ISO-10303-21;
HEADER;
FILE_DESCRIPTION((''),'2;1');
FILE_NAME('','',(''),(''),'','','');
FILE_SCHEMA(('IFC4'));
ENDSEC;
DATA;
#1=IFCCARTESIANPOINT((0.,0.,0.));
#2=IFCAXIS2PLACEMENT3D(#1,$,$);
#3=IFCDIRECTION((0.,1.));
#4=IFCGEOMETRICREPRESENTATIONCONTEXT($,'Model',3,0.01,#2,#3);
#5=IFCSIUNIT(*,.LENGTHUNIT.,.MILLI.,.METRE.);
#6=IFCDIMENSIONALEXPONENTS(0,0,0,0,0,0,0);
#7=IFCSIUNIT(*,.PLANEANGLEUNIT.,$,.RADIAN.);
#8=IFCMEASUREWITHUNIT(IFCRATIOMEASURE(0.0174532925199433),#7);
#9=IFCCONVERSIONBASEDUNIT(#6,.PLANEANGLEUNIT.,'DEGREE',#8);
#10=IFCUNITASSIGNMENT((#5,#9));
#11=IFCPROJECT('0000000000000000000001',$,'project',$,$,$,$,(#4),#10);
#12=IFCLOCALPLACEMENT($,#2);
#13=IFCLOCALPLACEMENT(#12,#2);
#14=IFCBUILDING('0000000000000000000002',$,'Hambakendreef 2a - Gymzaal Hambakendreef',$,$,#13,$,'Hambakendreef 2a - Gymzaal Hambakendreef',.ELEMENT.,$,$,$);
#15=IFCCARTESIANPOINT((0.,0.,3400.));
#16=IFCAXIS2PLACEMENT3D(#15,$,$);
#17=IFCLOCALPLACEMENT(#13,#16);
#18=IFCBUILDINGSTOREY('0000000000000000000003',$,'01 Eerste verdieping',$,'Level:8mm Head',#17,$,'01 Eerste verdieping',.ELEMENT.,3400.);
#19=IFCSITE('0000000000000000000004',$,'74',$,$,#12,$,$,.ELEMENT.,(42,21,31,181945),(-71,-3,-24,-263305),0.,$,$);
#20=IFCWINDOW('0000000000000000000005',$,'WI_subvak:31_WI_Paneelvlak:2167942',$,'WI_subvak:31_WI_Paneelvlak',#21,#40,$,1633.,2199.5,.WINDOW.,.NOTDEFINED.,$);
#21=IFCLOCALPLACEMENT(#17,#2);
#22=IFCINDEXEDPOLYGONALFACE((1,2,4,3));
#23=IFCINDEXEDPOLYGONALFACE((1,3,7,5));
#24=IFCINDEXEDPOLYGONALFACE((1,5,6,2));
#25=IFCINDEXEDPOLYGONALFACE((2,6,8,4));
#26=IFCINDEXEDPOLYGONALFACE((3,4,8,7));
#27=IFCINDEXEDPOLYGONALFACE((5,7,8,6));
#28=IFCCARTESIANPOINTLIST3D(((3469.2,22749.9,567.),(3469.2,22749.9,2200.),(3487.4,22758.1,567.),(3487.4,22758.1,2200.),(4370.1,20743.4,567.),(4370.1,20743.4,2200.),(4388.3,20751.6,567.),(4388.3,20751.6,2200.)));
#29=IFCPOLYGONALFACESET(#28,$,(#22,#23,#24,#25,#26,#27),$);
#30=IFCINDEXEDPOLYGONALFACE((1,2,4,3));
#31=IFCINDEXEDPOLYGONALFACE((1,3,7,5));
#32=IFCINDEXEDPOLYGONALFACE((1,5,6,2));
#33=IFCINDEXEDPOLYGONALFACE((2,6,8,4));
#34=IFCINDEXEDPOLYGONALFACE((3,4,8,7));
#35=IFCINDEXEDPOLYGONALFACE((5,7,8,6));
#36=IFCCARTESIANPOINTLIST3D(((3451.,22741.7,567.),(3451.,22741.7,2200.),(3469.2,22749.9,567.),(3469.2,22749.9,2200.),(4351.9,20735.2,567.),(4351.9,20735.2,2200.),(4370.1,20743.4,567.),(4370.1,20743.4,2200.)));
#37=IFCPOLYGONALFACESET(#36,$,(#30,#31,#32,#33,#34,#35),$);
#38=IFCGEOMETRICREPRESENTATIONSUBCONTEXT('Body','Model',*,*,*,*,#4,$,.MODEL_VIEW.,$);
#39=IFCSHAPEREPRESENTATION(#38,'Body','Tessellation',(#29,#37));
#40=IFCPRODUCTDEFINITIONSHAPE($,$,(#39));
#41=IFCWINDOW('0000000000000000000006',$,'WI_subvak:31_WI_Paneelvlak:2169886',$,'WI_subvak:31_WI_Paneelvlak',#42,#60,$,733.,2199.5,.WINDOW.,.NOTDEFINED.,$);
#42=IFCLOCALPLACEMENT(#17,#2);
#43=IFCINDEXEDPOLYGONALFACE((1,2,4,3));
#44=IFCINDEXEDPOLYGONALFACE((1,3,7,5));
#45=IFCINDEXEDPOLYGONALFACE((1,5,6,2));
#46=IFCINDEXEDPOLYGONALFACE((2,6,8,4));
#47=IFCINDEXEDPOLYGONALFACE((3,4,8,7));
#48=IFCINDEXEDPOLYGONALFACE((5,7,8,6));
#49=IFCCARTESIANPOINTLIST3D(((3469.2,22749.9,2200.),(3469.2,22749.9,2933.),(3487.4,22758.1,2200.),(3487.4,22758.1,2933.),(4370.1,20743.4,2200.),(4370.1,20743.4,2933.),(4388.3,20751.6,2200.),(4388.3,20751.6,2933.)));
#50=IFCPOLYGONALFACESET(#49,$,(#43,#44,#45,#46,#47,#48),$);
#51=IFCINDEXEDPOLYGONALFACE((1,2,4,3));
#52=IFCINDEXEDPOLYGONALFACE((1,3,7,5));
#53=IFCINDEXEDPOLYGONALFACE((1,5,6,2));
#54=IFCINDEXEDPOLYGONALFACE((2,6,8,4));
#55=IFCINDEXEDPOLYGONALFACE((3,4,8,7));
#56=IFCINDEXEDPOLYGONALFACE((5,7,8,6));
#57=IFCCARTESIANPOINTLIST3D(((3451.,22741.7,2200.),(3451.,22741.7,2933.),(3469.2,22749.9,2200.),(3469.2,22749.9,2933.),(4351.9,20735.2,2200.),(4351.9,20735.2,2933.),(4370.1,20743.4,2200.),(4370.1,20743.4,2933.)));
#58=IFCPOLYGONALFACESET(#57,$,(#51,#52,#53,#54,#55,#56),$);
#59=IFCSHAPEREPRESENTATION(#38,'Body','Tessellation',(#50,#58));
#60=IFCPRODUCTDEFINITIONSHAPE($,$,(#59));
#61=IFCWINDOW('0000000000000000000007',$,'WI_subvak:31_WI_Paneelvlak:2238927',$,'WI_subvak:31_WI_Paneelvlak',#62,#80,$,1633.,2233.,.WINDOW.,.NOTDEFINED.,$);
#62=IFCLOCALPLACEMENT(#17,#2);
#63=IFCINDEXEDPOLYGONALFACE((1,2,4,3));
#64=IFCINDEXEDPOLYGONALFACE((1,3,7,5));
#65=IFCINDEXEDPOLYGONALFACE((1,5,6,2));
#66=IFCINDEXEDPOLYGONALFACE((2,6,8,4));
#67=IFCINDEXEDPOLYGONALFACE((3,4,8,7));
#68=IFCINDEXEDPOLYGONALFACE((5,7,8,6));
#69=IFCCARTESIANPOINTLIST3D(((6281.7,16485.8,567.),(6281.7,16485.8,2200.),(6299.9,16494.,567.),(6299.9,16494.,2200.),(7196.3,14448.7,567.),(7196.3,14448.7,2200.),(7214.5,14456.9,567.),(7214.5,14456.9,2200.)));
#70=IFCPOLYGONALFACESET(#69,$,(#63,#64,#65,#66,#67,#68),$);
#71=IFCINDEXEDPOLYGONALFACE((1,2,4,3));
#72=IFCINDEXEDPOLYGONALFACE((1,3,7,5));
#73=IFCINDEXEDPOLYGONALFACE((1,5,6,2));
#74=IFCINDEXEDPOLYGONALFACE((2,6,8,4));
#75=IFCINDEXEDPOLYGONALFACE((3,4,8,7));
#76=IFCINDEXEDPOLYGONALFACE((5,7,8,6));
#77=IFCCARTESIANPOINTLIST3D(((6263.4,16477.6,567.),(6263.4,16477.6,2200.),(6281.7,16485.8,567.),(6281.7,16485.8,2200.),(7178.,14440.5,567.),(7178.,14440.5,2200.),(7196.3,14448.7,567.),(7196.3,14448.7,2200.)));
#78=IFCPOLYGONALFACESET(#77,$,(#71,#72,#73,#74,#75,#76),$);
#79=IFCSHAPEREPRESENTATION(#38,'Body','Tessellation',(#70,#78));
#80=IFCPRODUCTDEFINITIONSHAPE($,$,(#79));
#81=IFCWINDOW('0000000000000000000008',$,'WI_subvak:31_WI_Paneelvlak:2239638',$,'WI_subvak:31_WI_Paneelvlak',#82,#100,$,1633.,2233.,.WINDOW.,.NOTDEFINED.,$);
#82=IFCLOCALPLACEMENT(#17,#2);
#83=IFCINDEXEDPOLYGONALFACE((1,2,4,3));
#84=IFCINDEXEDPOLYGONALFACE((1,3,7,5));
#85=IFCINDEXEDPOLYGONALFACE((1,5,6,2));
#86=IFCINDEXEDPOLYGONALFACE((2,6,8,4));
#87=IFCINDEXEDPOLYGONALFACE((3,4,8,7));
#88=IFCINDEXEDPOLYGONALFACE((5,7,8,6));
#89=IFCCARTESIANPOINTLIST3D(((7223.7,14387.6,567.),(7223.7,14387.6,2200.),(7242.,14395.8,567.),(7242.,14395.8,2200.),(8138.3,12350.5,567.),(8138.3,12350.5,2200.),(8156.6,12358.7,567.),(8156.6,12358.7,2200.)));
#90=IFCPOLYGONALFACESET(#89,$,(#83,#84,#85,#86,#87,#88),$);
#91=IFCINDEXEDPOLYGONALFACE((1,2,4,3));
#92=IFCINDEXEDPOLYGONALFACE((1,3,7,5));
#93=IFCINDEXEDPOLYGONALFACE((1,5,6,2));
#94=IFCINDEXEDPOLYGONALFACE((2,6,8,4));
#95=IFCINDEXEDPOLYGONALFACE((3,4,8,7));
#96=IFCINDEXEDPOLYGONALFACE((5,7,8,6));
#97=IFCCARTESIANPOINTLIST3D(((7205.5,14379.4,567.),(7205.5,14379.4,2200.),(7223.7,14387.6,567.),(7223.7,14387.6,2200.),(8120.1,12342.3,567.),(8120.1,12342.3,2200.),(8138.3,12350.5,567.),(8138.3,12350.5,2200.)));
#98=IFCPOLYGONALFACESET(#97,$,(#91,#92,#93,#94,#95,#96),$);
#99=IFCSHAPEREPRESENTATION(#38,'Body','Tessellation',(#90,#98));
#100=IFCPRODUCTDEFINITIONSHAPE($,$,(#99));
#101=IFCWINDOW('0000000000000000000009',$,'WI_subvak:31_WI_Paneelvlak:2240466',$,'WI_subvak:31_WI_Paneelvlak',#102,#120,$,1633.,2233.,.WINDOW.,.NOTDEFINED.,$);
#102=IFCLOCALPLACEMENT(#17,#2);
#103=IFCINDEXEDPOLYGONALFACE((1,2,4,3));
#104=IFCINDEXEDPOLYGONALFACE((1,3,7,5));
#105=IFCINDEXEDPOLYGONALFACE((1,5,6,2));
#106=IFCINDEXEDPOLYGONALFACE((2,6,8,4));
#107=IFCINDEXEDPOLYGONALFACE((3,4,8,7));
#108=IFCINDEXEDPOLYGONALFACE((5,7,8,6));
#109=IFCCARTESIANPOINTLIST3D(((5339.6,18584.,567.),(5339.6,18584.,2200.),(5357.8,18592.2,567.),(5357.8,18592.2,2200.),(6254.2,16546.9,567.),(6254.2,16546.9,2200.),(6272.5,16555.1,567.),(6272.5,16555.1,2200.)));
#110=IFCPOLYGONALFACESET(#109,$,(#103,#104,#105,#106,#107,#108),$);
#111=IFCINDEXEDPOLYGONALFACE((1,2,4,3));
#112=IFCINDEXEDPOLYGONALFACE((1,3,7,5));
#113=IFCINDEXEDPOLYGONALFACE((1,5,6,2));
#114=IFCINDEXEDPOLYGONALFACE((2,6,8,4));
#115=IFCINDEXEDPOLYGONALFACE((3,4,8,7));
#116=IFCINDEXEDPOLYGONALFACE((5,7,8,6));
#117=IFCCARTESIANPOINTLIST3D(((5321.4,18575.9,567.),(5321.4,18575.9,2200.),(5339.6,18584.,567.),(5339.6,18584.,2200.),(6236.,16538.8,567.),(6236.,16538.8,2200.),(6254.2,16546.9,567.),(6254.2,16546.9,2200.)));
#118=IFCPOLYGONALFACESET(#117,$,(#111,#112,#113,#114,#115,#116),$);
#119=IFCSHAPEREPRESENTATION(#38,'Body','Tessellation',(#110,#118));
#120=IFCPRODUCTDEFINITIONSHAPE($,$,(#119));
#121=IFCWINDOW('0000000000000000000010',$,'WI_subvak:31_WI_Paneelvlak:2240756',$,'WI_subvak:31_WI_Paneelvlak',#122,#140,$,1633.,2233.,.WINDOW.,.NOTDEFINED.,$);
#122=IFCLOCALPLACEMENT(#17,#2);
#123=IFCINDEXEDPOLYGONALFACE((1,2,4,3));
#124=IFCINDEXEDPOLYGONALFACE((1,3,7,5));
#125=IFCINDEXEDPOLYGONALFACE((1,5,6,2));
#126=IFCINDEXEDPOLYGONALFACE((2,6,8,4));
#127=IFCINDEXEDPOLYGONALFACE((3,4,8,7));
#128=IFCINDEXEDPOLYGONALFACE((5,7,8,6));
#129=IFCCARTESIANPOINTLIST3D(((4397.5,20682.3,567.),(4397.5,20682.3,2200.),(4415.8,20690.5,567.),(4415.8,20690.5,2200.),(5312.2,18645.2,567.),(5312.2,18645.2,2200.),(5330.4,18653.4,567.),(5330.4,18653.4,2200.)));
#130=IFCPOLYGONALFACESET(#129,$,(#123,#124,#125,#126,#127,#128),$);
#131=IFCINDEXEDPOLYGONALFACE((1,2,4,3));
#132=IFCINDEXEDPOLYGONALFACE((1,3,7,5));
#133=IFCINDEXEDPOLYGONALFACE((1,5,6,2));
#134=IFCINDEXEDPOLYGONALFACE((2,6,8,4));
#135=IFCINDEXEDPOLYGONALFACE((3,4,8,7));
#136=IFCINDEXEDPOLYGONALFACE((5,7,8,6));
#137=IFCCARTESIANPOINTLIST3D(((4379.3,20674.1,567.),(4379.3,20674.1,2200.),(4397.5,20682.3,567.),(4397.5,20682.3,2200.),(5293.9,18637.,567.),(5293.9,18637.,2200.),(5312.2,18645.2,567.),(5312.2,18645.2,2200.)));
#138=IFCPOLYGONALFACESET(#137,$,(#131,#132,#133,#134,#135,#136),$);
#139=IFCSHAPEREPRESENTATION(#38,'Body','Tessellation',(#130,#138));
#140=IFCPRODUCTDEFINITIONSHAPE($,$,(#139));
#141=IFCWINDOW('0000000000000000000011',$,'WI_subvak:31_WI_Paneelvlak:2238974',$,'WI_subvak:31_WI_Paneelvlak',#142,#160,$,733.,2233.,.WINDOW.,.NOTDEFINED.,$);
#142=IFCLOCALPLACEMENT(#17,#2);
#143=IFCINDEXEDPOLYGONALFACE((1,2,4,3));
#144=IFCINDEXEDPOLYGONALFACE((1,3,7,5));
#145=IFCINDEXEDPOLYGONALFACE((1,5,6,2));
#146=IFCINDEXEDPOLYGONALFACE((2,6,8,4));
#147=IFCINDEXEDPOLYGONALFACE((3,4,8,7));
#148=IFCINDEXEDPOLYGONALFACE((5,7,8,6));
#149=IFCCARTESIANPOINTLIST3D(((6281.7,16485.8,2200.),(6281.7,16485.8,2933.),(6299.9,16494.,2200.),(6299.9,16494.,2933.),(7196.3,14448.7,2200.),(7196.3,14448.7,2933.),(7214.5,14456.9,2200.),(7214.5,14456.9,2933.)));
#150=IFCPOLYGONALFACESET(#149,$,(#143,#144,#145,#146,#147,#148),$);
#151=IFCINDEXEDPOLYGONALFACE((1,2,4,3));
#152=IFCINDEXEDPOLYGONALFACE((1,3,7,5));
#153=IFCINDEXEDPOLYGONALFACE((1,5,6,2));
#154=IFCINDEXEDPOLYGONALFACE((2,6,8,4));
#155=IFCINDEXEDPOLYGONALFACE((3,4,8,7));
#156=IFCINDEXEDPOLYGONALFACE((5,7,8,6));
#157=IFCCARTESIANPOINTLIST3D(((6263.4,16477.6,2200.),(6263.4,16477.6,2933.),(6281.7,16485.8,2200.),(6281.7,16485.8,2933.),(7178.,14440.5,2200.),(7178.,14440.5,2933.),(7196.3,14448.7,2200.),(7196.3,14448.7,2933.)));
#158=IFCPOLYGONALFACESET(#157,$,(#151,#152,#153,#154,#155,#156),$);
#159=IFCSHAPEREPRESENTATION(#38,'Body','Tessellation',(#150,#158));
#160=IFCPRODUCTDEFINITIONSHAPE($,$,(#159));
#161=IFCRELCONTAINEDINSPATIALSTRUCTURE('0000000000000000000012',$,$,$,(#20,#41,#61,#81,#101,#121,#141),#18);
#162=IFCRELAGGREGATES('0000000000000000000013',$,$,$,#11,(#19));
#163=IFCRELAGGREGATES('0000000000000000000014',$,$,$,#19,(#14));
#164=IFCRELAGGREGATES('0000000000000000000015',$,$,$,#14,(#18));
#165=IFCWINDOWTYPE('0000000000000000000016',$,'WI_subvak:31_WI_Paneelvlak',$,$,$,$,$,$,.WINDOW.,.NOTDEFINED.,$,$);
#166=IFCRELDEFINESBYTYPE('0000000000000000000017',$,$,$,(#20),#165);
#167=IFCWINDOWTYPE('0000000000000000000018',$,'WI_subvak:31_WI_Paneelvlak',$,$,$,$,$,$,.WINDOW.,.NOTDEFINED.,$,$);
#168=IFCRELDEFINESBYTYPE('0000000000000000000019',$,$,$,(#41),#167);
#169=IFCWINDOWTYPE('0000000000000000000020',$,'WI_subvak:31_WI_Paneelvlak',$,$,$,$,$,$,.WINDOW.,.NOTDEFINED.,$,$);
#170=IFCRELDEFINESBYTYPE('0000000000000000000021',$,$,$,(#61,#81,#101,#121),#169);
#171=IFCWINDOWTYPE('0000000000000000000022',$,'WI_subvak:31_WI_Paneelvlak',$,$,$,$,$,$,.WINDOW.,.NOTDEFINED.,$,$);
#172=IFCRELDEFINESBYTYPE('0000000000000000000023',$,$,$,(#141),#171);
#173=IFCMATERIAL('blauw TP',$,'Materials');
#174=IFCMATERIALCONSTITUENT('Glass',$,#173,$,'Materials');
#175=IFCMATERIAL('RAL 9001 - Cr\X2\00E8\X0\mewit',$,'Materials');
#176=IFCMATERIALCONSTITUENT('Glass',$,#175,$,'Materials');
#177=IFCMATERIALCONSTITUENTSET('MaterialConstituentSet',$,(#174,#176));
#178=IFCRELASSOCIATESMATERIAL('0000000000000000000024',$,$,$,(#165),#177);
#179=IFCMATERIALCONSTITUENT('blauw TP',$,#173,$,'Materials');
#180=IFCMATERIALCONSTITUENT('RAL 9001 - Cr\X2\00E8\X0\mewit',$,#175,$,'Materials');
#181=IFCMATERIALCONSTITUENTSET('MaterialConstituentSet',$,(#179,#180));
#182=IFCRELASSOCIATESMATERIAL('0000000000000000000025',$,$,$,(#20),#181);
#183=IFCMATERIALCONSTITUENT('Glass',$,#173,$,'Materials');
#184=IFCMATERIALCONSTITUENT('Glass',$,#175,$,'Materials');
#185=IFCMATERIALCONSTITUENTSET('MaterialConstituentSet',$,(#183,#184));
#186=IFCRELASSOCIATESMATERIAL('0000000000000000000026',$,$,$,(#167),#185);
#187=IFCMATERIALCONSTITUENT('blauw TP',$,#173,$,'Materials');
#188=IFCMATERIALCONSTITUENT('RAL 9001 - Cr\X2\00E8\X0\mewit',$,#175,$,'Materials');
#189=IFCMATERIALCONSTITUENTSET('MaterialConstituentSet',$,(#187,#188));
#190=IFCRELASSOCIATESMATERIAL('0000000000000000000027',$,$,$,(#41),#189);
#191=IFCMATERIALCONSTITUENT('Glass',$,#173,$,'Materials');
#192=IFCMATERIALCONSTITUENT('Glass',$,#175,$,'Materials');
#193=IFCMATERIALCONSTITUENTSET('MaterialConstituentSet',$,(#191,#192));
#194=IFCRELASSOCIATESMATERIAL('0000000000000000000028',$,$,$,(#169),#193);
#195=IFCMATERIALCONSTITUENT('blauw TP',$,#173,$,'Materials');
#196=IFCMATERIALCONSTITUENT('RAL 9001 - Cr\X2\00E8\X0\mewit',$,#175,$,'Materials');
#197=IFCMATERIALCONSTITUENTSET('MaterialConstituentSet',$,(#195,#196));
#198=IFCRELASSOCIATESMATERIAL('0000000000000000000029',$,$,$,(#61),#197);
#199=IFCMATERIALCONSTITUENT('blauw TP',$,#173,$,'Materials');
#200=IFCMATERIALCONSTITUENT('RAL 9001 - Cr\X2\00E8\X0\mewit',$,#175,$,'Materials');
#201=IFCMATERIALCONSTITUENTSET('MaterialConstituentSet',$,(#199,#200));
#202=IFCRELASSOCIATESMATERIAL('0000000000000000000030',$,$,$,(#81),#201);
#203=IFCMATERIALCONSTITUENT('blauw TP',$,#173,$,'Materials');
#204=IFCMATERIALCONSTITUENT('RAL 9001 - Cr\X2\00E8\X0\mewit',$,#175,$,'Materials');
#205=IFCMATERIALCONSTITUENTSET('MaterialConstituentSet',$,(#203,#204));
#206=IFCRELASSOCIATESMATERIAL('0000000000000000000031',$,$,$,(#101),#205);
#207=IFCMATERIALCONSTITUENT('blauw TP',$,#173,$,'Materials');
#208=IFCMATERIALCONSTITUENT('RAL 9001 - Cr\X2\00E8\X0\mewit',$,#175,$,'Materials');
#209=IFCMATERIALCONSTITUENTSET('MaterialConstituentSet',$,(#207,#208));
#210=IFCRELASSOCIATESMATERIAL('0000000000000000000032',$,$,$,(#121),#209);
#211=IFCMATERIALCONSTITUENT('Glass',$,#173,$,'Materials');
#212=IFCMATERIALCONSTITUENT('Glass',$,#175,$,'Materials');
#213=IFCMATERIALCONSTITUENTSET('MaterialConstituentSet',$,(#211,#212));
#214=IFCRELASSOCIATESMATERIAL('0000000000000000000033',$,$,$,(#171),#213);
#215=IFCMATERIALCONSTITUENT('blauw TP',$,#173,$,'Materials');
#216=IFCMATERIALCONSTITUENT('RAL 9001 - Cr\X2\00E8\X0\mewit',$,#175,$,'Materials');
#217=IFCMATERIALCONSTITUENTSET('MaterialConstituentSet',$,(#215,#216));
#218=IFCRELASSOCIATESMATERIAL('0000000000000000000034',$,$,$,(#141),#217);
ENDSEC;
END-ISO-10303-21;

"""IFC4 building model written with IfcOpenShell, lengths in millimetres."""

from ifc_helpers import new_model, entity, si_unit, converted_unit, direction, frame, origin, place, context, subcontext, project, spatial, indexed_curve, outline, extrude, source, transform, mapped, material, constituent, constituent_set, type_object, type_shapes, element, save


model = new_model("IFC4")

# Units and contexts
model_context = context("Model", 3, precision=0.01, world=origin(), true_north=direction((0.0, 1.0)))
body_context = subcontext(model_context, "Body", "Model", "MODEL_VIEW")
ifc_project = project(units=[si_unit("LENGTHUNIT", "METRE", prefix="MILLI"), converted_unit("PLANEANGLEUNIT", "DEGREE", entity("IfcRatioMeasure", 0.0174532925199433), si_unit("PLANEANGLEUNIT", "RADIAN"), dimensions=[0, 0, 0, 0, 0, 0, 0])], contexts=[model_context])

# Site, building, storey
site_placement = place(None, origin())
site = spatial("IfcSite", under=ifc_project, at=site_placement, Name="74", CompositionType="ELEMENT", RefLatitude=(42, 21, 31, 181945), RefLongitude=(-71, -3, -24, -263305), RefElevation=0.0)
building_placement = place(site_placement, origin())
building = spatial("IfcBuilding", under=site, at=building_placement, Name="Hambakendreef 2a - Gymzaal Hambakendreef", LongName="Hambakendreef 2a - Gymzaal Hambakendreef", CompositionType="ELEMENT")
storey_placement = place(building_placement, frame((0.0, 0.0, 3400.0)))
storey = spatial("IfcBuildingStorey", under=building, at=storey_placement, Name="01 Eerste verdieping", ObjectType="Level:8mm Head", LongName="01 Eerste verdieping", CompositionType="ELEMENT", Elevation=3400.0)

# Windows
ifc_material_1 = material(Name="blauw TP", Category="Materials")
ifc_constituent_1 = constituent(ifc_material_1, Name="blauw TP", Category="Materials")
ifc_material_2 = material(Name="RAL 9001 - Crèmewit", Category="Materials")
ifc_constituent_2 = constituent(ifc_material_2, Name="RAL 9001 - Crèmewit", Category="Materials")
ifc_constituent_set_1 = constituent_set(constituents=[ifc_constituent_1, ifc_constituent_2], Name="MaterialConstituentSet")
ifc_constituent_3 = constituent(ifc_material_1, Name="Glass", Category="Materials")
ifc_constituent_4 = constituent(ifc_material_2, Name="Glass", Category="Materials")
ifc_constituent_set_2 = constituent_set(constituents=[ifc_constituent_3, ifc_constituent_4], Name="MaterialConstituentSet")
window_type_1 = type_object("IfcWindowType", Name="WI_subvak:31_WI_Paneelvlak", PartitioningType="NOTDEFINED", PredefinedType="WINDOW", material=ifc_constituent_set_2)
shared_shape_1 = source(origin(), body_context, "Body", "SweptSolid", [
    extrude(outline(indexed_curve([(-10.0, -1099.8), (10.0, -1099.8), (10.0, 1099.8), (-10.0, 1099.8), (-10.0, -1099.8)], self_intersect=False)), frame((0.0, 10.0, 0.0), z_axis=(0.0, 0.0, 1.0), x_axis=(0.0, -1.0, 0.0)), (0.0, 0.0, 1.0), 1633.0),
    extrude(outline(indexed_curve([(-10.0, -1099.8), (10.0, -1099.8), (10.0, 1099.8), (-10.0, 1099.8), (-10.0, -1099.8)], self_intersect=False)), frame((0.0, -10.0, 0.0), z_axis=(0.0, 0.0, 1.0), x_axis=(0.0, -1.0, 0.0)), (0.0, 0.0, 1.0), 1633.0),
])
type_shapes(window_type_1, [shared_shape_1])
window_1_placement = place(storey_placement, frame((3919.7, 21746.7, 567.0), z_axis=(0.0, 0.0, 1.0), x_axis=(0.40959, -0.91227, 0.0)))
element("IfcWindow", 1, at=window_1_placement, inside=storey, type_object=window_type_1, material=ifc_constituent_set_1, Name="WI_subvak:31_WI_Paneelvlak:2167942", ObjectType="WI_subvak:31_WI_Paneelvlak", OverallHeight=1633.0, OverallWidth=2199.5, PartitioningType="NOTDEFINED", PredefinedType="WINDOW", context=body_context, shape_type="MappedRepresentation", body=[
    mapped(shared_shape_1, transform((0.0, 0.0, 0.0), scale=1.0)),
])
ifc_constituent_5 = constituent(ifc_material_1, Name="blauw TP", Category="Materials")
ifc_constituent_6 = constituent(ifc_material_2, Name="RAL 9001 - Crèmewit", Category="Materials")
ifc_constituent_set_3 = constituent_set(constituents=[ifc_constituent_5, ifc_constituent_6], Name="MaterialConstituentSet")
ifc_constituent_7 = constituent(ifc_material_1, Name="Glass", Category="Materials")
ifc_constituent_8 = constituent(ifc_material_2, Name="Glass", Category="Materials")
ifc_constituent_set_4 = constituent_set(constituents=[ifc_constituent_7, ifc_constituent_8], Name="MaterialConstituentSet")
window_type_2 = type_object("IfcWindowType", Name="WI_subvak:31_WI_Paneelvlak", PartitioningType="NOTDEFINED", PredefinedType="WINDOW", material=ifc_constituent_set_4)
shared_shape_2 = source(origin(), body_context, "Body", "SweptSolid", [
    extrude(outline(indexed_curve([(-10.0, -1099.8), (10.0, -1099.8), (10.0, 1099.8), (-10.0, 1099.8), (-10.0, -1099.8)], self_intersect=False)), frame((0.0, 10.0, 0.0), z_axis=(0.0, 0.0, 1.0), x_axis=(0.0, -1.0, 0.0)), (0.0, 0.0, 1.0), 733.0),
    extrude(outline(indexed_curve([(-10.0, -1099.8), (10.0, -1099.8), (10.0, 1099.8), (-10.0, 1099.8), (-10.0, -1099.8)], self_intersect=False)), frame((0.0, -10.0, 0.0), z_axis=(0.0, 0.0, 1.0), x_axis=(0.0, -1.0, 0.0)), (0.0, 0.0, 1.0), 733.0),
])
type_shapes(window_type_2, [shared_shape_2])
window_2_placement = place(storey_placement, frame((3919.7, 21746.7, 2200.0), z_axis=(0.0, 0.0, 1.0), x_axis=(0.40959, -0.91227, 0.0)))
element("IfcWindow", 2, at=window_2_placement, inside=storey, type_object=window_type_2, material=ifc_constituent_set_3, Name="WI_subvak:31_WI_Paneelvlak:2169886", ObjectType="WI_subvak:31_WI_Paneelvlak", OverallHeight=733.0, OverallWidth=2199.5, PartitioningType="NOTDEFINED", PredefinedType="WINDOW", context=body_context, shape_type="MappedRepresentation", body=[
    mapped(shared_shape_2, transform((0.0, 0.0, 0.0), scale=1.0)),
])
ifc_constituent_9 = constituent(ifc_material_1, Name="blauw TP", Category="Materials")
ifc_constituent_10 = constituent(ifc_material_2, Name="RAL 9001 - Crèmewit", Category="Materials")
ifc_constituent_set_5 = constituent_set(constituents=[ifc_constituent_9, ifc_constituent_10], Name="MaterialConstituentSet")
ifc_constituent_11 = constituent(ifc_material_1, Name="Glass", Category="Materials")
ifc_constituent_12 = constituent(ifc_material_2, Name="Glass", Category="Materials")
ifc_constituent_set_6 = constituent_set(constituents=[ifc_constituent_11, ifc_constituent_12], Name="MaterialConstituentSet")
window_type_3 = type_object("IfcWindowType", Name="WI_subvak:31_WI_Paneelvlak", PartitioningType="NOTDEFINED", PredefinedType="WINDOW", material=ifc_constituent_set_6)
shared_shape_3 = source(origin(), body_context, "Body", "SweptSolid", [
    extrude(outline(indexed_curve([(-10.0, -1116.5), (10.0, -1116.5), (10.0, 1116.5), (-10.0, 1116.5), (-10.0, -1116.5)], self_intersect=False)), frame((0.0, 10.0, 0.0), z_axis=(0.0, 0.0, 1.0), x_axis=(0.0, -1.0, 0.0)), (0.0, 0.0, 1.0), 1633.0),
    extrude(outline(indexed_curve([(-10.0, -1116.5), (10.0, -1116.5), (10.0, 1116.5), (-10.0, 1116.5), (-10.0, -1116.5)], self_intersect=False)), frame((0.0, -10.0, 0.0), z_axis=(0.0, 0.0, 1.0), x_axis=(0.0, -1.0, 0.0)), (0.0, 0.0, 1.0), 1633.0),
])
type_shapes(window_type_3, [shared_shape_3])
window_3_placement = place(storey_placement, frame((6739.0, 15467.3, 567.0), z_axis=(0.0, 0.0, 1.0), x_axis=(0.40959, -0.91227, 0.0)))
element("IfcWindow", 3, at=window_3_placement, inside=storey, type_object=window_type_3, material=ifc_constituent_set_5, Name="WI_subvak:31_WI_Paneelvlak:2238927", ObjectType="WI_subvak:31_WI_Paneelvlak", OverallHeight=1633.0, OverallWidth=2233.0, PartitioningType="NOTDEFINED", PredefinedType="WINDOW", context=body_context, shape_type="MappedRepresentation", body=[
    mapped(shared_shape_3, transform((0.0, 0.0, 0.0), scale=1.0)),
])
ifc_constituent_13 = constituent(ifc_material_1, Name="blauw TP", Category="Materials")
ifc_constituent_14 = constituent(ifc_material_2, Name="RAL 9001 - Crèmewit", Category="Materials")
ifc_constituent_set_7 = constituent_set(constituents=[ifc_constituent_13, ifc_constituent_14], Name="MaterialConstituentSet")
window_4_placement = place(storey_placement, frame((7681.0, 13369.1, 567.0), z_axis=(0.0, 0.0, 1.0), x_axis=(0.40959, -0.91227, 0.0)))
element("IfcWindow", 4, at=window_4_placement, inside=storey, type_object=window_type_3, material=ifc_constituent_set_7, Name="WI_subvak:31_WI_Paneelvlak:2239638", ObjectType="WI_subvak:31_WI_Paneelvlak", OverallHeight=1633.0, OverallWidth=2233.0, PartitioningType="NOTDEFINED", PredefinedType="WINDOW", context=body_context, shape_type="MappedRepresentation", body=[
    mapped(shared_shape_3, transform((0.0, 0.0, 0.0), scale=1.0)),
])
ifc_constituent_15 = constituent(ifc_material_1, Name="blauw TP", Category="Materials")
ifc_constituent_16 = constituent(ifc_material_2, Name="RAL 9001 - Crèmewit", Category="Materials")
ifc_constituent_set_8 = constituent_set(constituents=[ifc_constituent_15, ifc_constituent_16], Name="MaterialConstituentSet")
window_5_placement = place(storey_placement, frame((5796.9, 17565.5, 567.0), z_axis=(0.0, 0.0, 1.0), x_axis=(0.40959, -0.91227, 0.0)))
element("IfcWindow", 5, at=window_5_placement, inside=storey, type_object=window_type_3, material=ifc_constituent_set_8, Name="WI_subvak:31_WI_Paneelvlak:2240466", ObjectType="WI_subvak:31_WI_Paneelvlak", OverallHeight=1633.0, OverallWidth=2233.0, PartitioningType="NOTDEFINED", PredefinedType="WINDOW", context=body_context, shape_type="MappedRepresentation", body=[
    mapped(shared_shape_3, transform((0.0, 0.0, 0.0), scale=1.0)),
])
ifc_constituent_17 = constituent(ifc_material_1, Name="blauw TP", Category="Materials")
ifc_constituent_18 = constituent(ifc_material_2, Name="RAL 9001 - Crèmewit", Category="Materials")
ifc_constituent_set_9 = constituent_set(constituents=[ifc_constituent_17, ifc_constituent_18], Name="MaterialConstituentSet")
window_6_placement = place(storey_placement, frame((4854.8, 19663.7, 567.0), z_axis=(0.0, 0.0, 1.0), x_axis=(0.40959, -0.91227, 0.0)))
element("IfcWindow", 6, at=window_6_placement, inside=storey, type_object=window_type_3, material=ifc_constituent_set_9, Name="WI_subvak:31_WI_Paneelvlak:2240756", ObjectType="WI_subvak:31_WI_Paneelvlak", OverallHeight=1633.0, OverallWidth=2233.0, PartitioningType="NOTDEFINED", PredefinedType="WINDOW", context=body_context, shape_type="MappedRepresentation", body=[
    mapped(shared_shape_3, transform((0.0, 0.0, 0.0), scale=1.0)),
])
ifc_constituent_19 = constituent(ifc_material_1, Name="blauw TP", Category="Materials")
ifc_constituent_20 = constituent(ifc_material_2, Name="RAL 9001 - Crèmewit", Category="Materials")
ifc_constituent_set_10 = constituent_set(constituents=[ifc_constituent_19, ifc_constituent_20], Name="MaterialConstituentSet")
ifc_constituent_21 = constituent(ifc_material_1, Name="Glass", Category="Materials")
ifc_constituent_22 = constituent(ifc_material_2, Name="Glass", Category="Materials")
ifc_constituent_set_11 = constituent_set(constituents=[ifc_constituent_21, ifc_constituent_22], Name="MaterialConstituentSet")
window_type_4 = type_object("IfcWindowType", Name="WI_subvak:31_WI_Paneelvlak", PartitioningType="NOTDEFINED", PredefinedType="WINDOW", material=ifc_constituent_set_11)
shared_shape_4 = source(origin(), body_context, "Body", "SweptSolid", [
    extrude(outline(indexed_curve([(-10.0, -1116.5), (10.0, -1116.5), (10.0, 1116.5), (-10.0, 1116.5), (-10.0, -1116.5)], self_intersect=False)), frame((0.0, 10.0, 0.0), z_axis=(0.0, 0.0, 1.0), x_axis=(0.0, -1.0, 0.0)), (0.0, 0.0, 1.0), 733.0),
    extrude(outline(indexed_curve([(-10.0, -1116.5), (10.0, -1116.5), (10.0, 1116.5), (-10.0, 1116.5), (-10.0, -1116.5)], self_intersect=False)), frame((0.0, -10.0, 0.0), z_axis=(0.0, 0.0, 1.0), x_axis=(0.0, -1.0, 0.0)), (0.0, 0.0, 1.0), 733.0),
])
type_shapes(window_type_4, [shared_shape_4])
window_7_placement = place(storey_placement, frame((6739.0, 15467.3, 2200.0), z_axis=(0.0, 0.0, 1.0), x_axis=(0.40959, -0.91227, 0.0)))
element("IfcWindow", 7, at=window_7_placement, inside=storey, type_object=window_type_4, material=ifc_constituent_set_10, Name="WI_subvak:31_WI_Paneelvlak:2238974", ObjectType="WI_subvak:31_WI_Paneelvlak", OverallHeight=733.0, OverallWidth=2233.0, PartitioningType="NOTDEFINED", PredefinedType="WINDOW", context=body_context, shape_type="MappedRepresentation", body=[
    mapped(shared_shape_4, transform((0.0, 0.0, 0.0), scale=1.0)),
])

save(model, "model.ifc")
